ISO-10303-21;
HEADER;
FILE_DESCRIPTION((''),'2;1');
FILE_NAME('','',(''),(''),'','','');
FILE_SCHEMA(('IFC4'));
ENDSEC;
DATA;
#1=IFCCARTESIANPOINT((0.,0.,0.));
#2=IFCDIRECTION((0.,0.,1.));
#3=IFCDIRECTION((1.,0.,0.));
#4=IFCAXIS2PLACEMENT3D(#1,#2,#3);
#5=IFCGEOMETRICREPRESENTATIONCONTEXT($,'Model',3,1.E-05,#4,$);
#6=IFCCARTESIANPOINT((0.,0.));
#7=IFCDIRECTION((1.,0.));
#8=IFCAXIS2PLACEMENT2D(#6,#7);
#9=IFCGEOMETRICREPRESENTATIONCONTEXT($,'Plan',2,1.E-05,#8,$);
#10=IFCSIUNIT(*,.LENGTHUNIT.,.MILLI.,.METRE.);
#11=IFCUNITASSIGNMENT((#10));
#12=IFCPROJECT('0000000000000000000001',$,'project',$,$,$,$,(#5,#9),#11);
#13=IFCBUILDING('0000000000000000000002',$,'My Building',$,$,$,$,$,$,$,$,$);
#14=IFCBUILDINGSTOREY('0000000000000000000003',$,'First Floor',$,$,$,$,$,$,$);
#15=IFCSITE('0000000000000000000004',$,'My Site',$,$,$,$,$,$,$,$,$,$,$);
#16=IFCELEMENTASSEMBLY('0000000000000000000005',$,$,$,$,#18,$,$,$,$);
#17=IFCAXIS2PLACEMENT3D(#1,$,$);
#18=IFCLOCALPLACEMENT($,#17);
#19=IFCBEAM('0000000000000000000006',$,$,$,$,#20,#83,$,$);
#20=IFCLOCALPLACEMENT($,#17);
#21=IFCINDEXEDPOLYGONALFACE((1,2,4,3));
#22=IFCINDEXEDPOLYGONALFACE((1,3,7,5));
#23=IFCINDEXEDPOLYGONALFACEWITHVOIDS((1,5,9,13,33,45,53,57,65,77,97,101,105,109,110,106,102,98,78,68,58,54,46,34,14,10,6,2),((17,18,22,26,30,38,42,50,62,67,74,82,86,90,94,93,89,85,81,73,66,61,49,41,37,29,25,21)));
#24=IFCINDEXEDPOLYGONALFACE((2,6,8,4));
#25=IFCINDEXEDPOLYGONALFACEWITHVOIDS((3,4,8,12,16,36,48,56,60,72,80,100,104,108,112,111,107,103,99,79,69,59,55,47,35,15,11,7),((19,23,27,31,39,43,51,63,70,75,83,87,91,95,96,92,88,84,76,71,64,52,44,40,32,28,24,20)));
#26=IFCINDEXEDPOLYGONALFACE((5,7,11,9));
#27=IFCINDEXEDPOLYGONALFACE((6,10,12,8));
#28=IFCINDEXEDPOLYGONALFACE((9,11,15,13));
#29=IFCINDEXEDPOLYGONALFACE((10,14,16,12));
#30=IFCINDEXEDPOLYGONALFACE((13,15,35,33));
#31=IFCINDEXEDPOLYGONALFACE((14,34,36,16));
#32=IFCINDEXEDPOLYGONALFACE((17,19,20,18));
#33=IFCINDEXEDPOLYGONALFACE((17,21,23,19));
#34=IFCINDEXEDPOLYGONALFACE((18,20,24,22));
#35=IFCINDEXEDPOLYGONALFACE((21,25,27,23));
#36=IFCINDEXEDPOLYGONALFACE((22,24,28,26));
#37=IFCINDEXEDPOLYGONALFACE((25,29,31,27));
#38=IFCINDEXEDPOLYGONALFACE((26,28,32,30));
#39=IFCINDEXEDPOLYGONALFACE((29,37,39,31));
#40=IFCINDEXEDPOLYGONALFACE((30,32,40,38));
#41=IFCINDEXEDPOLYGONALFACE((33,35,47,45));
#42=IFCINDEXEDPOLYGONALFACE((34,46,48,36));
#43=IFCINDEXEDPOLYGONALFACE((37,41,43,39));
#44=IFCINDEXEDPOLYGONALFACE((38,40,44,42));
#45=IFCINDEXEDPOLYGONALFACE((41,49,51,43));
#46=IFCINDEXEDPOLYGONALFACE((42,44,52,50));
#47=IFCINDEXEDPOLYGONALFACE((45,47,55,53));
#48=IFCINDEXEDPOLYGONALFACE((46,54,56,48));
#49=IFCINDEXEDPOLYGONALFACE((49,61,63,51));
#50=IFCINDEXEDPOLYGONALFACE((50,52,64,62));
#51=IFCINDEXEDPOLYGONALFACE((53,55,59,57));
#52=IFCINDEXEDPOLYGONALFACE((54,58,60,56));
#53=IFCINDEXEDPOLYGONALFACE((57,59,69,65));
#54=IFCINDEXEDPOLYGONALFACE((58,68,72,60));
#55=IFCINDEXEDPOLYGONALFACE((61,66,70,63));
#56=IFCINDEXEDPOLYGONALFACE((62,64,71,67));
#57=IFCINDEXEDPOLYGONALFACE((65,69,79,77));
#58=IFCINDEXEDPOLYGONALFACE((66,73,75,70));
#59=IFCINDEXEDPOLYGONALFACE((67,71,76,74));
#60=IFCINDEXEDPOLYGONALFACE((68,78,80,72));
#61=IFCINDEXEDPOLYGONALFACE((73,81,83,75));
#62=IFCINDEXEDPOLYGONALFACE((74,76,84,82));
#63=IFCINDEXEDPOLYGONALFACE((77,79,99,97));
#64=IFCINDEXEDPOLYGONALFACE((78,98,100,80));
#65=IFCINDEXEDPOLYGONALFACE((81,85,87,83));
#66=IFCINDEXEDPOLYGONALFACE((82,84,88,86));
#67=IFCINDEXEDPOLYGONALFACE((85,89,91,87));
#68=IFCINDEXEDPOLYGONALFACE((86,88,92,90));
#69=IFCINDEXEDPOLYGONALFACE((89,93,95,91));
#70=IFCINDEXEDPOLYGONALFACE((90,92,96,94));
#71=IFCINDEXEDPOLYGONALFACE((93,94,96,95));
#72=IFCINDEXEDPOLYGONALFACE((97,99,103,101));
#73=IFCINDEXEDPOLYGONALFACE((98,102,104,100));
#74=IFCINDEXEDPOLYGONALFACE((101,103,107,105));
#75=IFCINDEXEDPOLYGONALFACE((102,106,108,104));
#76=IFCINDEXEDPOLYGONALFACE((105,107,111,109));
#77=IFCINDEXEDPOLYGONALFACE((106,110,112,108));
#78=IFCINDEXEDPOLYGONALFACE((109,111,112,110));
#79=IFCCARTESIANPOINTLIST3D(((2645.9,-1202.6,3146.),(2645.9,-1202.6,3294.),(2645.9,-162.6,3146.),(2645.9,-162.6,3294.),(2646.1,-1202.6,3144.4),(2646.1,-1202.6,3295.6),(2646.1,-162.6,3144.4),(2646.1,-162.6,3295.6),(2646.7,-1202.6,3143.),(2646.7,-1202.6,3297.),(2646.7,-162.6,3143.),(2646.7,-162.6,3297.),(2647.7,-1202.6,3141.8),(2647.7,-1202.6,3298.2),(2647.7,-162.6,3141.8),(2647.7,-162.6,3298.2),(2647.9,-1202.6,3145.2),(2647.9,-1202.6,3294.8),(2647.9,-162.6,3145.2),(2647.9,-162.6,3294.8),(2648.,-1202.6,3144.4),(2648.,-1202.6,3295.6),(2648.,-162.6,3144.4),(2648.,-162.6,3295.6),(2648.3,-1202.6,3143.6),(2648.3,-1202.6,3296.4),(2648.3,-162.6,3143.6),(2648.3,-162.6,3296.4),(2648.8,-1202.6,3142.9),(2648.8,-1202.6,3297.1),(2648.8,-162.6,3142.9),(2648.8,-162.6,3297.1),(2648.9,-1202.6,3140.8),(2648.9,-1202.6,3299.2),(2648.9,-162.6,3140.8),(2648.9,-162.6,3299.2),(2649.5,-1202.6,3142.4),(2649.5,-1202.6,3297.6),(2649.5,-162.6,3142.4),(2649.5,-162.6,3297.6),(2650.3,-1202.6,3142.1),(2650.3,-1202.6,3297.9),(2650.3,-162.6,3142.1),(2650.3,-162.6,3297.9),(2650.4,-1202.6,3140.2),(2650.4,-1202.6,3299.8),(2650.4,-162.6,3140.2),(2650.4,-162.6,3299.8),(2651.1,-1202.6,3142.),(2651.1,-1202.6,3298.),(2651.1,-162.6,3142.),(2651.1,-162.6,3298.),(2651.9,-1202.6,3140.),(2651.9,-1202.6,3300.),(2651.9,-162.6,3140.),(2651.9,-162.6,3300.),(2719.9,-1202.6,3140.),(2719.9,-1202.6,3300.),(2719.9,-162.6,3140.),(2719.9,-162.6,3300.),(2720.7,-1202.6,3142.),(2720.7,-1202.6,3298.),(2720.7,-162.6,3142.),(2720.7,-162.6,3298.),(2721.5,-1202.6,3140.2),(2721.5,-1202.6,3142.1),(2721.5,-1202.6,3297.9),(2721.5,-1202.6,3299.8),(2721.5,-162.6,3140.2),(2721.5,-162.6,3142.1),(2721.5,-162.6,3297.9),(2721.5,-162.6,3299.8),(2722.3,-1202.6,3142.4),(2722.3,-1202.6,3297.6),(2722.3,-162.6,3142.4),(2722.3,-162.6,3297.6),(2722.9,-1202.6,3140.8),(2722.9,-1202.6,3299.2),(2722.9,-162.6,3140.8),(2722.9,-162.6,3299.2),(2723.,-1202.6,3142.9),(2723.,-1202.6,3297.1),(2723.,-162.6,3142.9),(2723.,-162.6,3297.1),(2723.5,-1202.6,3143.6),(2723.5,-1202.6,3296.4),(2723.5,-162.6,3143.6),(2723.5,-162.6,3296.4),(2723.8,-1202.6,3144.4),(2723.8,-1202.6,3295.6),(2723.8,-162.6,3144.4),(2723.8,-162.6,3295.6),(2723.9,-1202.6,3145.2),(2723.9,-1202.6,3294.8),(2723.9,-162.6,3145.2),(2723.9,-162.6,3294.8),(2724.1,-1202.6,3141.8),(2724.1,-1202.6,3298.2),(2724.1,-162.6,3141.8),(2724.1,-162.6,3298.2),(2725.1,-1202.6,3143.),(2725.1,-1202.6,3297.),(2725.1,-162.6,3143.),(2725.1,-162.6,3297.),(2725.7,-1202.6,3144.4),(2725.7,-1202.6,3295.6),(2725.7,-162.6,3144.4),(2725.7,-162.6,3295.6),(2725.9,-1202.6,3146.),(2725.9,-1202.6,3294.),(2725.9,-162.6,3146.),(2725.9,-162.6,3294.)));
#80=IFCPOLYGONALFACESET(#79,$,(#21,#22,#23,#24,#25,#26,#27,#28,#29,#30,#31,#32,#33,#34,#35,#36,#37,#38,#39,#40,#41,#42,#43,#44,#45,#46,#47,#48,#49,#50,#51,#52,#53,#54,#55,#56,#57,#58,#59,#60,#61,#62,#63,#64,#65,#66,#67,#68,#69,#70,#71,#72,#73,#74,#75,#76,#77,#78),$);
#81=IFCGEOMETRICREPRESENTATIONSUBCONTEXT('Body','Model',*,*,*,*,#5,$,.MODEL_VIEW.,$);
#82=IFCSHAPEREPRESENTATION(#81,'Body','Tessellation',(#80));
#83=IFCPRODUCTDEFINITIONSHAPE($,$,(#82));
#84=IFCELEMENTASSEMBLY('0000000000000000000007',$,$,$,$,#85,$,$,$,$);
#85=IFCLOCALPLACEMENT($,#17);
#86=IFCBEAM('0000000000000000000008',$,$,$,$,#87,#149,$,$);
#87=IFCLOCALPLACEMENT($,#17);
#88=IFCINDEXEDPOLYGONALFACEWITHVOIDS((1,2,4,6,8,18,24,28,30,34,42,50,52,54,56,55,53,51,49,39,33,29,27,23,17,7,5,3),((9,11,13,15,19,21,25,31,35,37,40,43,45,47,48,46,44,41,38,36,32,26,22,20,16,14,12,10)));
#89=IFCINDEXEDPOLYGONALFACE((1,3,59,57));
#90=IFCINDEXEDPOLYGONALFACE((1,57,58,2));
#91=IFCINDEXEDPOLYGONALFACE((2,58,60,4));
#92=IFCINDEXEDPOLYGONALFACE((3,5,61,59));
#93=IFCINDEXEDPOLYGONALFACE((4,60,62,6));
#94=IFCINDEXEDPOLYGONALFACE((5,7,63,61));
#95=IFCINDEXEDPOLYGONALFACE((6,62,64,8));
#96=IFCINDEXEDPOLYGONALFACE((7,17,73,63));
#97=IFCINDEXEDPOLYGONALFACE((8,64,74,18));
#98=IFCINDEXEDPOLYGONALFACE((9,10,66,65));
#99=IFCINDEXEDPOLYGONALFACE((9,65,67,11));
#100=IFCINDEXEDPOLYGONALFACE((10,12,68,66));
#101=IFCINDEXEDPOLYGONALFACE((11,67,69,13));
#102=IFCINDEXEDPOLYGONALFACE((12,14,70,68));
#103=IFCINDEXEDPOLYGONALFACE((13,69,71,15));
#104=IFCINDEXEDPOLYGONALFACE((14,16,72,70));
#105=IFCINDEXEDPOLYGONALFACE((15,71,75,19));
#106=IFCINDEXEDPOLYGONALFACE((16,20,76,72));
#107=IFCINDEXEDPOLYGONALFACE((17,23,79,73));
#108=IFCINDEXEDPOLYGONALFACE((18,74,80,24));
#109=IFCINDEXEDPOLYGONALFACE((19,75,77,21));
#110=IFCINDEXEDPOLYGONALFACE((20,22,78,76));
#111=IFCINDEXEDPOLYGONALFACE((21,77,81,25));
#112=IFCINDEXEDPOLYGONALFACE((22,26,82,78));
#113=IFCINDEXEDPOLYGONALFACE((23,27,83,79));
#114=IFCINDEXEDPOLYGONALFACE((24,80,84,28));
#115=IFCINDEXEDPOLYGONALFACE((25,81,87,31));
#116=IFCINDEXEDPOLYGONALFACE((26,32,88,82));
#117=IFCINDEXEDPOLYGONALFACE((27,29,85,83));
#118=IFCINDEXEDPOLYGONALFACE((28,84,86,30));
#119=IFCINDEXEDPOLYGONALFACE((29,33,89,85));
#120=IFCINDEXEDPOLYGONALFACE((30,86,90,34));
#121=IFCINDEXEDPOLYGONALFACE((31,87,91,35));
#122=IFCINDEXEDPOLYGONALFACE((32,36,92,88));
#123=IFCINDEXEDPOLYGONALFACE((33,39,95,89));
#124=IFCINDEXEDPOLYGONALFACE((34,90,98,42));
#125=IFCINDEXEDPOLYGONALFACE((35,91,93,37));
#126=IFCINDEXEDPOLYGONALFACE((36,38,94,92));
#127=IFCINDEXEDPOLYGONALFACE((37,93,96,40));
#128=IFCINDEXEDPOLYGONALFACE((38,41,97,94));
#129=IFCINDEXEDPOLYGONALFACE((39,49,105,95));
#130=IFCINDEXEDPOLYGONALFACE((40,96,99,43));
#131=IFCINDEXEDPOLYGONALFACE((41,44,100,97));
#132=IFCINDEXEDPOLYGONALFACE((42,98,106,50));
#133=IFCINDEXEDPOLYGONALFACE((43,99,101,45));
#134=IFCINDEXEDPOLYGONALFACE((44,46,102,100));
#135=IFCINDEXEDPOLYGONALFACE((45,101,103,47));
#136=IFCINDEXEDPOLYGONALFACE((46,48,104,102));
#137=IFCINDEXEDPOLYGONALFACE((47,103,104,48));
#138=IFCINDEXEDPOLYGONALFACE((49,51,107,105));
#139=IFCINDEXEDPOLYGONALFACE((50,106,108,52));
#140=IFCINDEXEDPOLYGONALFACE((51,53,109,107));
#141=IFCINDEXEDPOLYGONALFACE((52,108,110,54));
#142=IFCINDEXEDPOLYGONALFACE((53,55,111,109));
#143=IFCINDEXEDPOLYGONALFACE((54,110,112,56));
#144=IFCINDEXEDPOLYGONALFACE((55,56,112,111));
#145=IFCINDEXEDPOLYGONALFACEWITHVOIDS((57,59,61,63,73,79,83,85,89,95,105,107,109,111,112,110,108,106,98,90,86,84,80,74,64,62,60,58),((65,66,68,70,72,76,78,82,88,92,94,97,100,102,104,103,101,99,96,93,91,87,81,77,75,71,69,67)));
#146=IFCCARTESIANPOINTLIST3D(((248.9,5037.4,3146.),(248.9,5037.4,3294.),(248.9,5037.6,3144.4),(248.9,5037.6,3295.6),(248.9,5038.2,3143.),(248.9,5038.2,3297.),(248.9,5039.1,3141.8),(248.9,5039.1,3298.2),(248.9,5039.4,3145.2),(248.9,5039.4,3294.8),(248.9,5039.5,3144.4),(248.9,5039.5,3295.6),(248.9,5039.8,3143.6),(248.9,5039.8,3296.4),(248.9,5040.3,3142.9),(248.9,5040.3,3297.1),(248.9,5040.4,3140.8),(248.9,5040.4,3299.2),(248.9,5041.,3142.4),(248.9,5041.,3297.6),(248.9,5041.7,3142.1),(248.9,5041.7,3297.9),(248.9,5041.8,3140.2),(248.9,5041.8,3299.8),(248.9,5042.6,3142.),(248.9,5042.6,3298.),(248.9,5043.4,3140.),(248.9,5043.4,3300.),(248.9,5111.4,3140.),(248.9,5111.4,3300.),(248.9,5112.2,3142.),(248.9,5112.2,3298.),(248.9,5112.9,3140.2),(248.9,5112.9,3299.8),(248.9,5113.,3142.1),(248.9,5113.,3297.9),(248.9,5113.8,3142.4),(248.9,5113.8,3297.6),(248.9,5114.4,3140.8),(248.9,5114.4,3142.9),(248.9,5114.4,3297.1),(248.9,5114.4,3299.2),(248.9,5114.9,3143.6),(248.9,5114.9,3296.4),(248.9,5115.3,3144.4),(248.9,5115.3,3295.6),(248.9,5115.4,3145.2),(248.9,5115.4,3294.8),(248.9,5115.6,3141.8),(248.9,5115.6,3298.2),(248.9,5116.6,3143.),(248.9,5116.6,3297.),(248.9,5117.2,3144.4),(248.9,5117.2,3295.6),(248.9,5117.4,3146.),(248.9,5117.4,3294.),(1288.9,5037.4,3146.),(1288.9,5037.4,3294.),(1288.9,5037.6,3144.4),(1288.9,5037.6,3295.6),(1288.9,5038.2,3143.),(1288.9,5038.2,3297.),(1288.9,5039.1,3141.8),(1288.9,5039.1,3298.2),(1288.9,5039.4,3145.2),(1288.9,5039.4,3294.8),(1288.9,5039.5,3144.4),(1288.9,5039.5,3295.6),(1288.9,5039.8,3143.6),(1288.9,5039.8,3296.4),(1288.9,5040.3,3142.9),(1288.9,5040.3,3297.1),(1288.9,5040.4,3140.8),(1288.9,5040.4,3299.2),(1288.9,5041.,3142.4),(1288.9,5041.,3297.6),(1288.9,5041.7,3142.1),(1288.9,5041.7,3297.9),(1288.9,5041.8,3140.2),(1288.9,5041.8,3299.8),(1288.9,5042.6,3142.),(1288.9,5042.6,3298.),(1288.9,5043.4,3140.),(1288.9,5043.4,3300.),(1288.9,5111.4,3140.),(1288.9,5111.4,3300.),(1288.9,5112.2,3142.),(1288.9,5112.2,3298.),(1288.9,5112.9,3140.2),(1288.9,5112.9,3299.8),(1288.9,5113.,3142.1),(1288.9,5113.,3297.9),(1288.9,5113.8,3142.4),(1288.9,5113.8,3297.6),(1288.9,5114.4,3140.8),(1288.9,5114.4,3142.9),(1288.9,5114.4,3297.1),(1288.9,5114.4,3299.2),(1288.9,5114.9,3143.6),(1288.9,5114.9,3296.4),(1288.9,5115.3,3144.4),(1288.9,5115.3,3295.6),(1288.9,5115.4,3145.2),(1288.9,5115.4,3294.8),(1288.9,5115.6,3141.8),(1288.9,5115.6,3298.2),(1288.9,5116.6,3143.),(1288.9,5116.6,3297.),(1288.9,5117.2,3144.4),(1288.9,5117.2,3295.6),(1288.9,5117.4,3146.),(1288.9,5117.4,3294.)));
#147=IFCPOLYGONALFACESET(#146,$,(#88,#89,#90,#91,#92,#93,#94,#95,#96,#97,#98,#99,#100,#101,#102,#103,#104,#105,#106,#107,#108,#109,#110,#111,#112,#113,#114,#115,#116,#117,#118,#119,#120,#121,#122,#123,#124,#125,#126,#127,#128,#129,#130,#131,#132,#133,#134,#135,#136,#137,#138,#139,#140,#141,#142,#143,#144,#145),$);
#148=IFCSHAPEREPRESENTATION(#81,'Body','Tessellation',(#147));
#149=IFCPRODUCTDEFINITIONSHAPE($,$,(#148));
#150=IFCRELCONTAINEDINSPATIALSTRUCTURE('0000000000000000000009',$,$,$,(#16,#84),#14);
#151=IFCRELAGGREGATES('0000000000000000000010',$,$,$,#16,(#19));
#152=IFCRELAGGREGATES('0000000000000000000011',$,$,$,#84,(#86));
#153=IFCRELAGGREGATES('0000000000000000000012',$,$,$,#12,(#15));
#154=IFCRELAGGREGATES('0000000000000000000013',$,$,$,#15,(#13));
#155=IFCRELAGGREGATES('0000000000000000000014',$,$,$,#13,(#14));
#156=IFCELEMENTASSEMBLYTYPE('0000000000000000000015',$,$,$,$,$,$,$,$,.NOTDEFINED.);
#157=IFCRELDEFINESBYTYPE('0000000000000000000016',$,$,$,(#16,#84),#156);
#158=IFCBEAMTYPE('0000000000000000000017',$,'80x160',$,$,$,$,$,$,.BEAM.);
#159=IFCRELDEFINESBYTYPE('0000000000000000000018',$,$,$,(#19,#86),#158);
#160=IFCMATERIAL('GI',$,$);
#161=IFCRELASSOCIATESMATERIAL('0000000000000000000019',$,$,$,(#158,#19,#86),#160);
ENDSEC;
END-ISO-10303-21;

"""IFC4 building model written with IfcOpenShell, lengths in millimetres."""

from ifc_helpers import new_model, si_unit, frame, origin_with_axes, origin_2d_with_axis, place, context, subcontext, project, spatial, hollow_rectangle, extrude, material, material_profile, profile_set, profile_usage, type_object, element, aggregate, save


model = new_model("IFC4")

# Units and contexts
model_context = context("Model", 3, precision=1e-05, world=origin_with_axes())
plan_context = context("Plan", 2, precision=1e-05, world=origin_2d_with_axis())
body_context = subcontext(model_context, "Body", "Model", "MODEL_VIEW")
ifc_project = project(units=[si_unit("LENGTHUNIT", "METRE", prefix="MILLI")], contexts=[model_context, plan_context])

# Site, building, storey
site = spatial("IfcSite", under=ifc_project, Name="My Site")
building = spatial("IfcBuilding", under=site, Name="My Building")
storey = spatial("IfcBuildingStorey", under=building, Name="First Floor")

# Element assemblies, beams
element_assembly_type = type_object("IfcElementAssemblyType", PredefinedType="NOTDEFINED")
ifc_material = material(Name="GI")
ifc_material_profile = material_profile(ifc_material, hollow_rectangle(XDim=80.0, YDim=160.0, WallThickness=2.0, InnerFilletRadius=3.2, OuterFilletRadius=6.0))
ifc_profile_set = profile_set([ifc_material_profile], Name="80x160 GI Rectangular Hollow")
beam_type = type_object("IfcBeamType", Name="80x160", PredefinedType="BEAM", material=ifc_profile_set)
assembly_1_placement = place(None, frame((2685.9, -1282.6, 3220.0), z_axis=(0.0, 1.0, 0.0), x_axis=(1.0, 0.0, 0.0)))
assembly_1 = element("IfcElementAssembly", 1, at=assembly_1_placement, inside=storey, type_object=element_assembly_type)
ifc_profile_usage_1 = profile_usage(ifc_profile_set)
beam_1_placement = place(assembly_1_placement, frame((0.0, 0.0, 80.0), z_axis=(0.0, 0.0, 1.0), x_axis=(1.0, 0.0, 0.0)))
beam_1 = element("IfcBeam", 2, at=beam_1_placement, type_object=beam_type, material=ifc_profile_usage_1, context=body_context, shape_type="SweptSolid", body=[
    extrude(hollow_rectangle(XDim=80.0, YDim=160.0, WallThickness=2.0, InnerFilletRadius=3.2, OuterFilletRadius=6.0), origin_with_axes(), (0.0, 0.0, 1.0), 1040.0),
])
aggregate(assembly_1, [beam_1])
assembly_2_placement = place(None, frame((168.9, 5077.4, 3220.0), z_axis=(1.0, 0.0, 0.0), x_axis=(0.0, 1.0, 0.0)))
assembly_2 = element("IfcElementAssembly", 3, at=assembly_2_placement, inside=storey, type_object=element_assembly_type)
ifc_profile_usage_2 = profile_usage(ifc_profile_set)
beam_2_placement = place(assembly_2_placement, frame((0.0, 0.0, 80.0), z_axis=(0.0, 0.0, 1.0), x_axis=(1.0, 0.0, 0.0)))
beam_2 = element("IfcBeam", 4, at=beam_2_placement, type_object=beam_type, material=ifc_profile_usage_2, context=body_context, shape_type="SweptSolid", body=[
    extrude(hollow_rectangle(XDim=80.0, YDim=160.0, WallThickness=2.0, InnerFilletRadius=3.2, OuterFilletRadius=6.0), origin_with_axes(), (0.0, 0.0, 1.0), 1040.0),
])
aggregate(assembly_2, [beam_2])

save(model, "model.ifc")
